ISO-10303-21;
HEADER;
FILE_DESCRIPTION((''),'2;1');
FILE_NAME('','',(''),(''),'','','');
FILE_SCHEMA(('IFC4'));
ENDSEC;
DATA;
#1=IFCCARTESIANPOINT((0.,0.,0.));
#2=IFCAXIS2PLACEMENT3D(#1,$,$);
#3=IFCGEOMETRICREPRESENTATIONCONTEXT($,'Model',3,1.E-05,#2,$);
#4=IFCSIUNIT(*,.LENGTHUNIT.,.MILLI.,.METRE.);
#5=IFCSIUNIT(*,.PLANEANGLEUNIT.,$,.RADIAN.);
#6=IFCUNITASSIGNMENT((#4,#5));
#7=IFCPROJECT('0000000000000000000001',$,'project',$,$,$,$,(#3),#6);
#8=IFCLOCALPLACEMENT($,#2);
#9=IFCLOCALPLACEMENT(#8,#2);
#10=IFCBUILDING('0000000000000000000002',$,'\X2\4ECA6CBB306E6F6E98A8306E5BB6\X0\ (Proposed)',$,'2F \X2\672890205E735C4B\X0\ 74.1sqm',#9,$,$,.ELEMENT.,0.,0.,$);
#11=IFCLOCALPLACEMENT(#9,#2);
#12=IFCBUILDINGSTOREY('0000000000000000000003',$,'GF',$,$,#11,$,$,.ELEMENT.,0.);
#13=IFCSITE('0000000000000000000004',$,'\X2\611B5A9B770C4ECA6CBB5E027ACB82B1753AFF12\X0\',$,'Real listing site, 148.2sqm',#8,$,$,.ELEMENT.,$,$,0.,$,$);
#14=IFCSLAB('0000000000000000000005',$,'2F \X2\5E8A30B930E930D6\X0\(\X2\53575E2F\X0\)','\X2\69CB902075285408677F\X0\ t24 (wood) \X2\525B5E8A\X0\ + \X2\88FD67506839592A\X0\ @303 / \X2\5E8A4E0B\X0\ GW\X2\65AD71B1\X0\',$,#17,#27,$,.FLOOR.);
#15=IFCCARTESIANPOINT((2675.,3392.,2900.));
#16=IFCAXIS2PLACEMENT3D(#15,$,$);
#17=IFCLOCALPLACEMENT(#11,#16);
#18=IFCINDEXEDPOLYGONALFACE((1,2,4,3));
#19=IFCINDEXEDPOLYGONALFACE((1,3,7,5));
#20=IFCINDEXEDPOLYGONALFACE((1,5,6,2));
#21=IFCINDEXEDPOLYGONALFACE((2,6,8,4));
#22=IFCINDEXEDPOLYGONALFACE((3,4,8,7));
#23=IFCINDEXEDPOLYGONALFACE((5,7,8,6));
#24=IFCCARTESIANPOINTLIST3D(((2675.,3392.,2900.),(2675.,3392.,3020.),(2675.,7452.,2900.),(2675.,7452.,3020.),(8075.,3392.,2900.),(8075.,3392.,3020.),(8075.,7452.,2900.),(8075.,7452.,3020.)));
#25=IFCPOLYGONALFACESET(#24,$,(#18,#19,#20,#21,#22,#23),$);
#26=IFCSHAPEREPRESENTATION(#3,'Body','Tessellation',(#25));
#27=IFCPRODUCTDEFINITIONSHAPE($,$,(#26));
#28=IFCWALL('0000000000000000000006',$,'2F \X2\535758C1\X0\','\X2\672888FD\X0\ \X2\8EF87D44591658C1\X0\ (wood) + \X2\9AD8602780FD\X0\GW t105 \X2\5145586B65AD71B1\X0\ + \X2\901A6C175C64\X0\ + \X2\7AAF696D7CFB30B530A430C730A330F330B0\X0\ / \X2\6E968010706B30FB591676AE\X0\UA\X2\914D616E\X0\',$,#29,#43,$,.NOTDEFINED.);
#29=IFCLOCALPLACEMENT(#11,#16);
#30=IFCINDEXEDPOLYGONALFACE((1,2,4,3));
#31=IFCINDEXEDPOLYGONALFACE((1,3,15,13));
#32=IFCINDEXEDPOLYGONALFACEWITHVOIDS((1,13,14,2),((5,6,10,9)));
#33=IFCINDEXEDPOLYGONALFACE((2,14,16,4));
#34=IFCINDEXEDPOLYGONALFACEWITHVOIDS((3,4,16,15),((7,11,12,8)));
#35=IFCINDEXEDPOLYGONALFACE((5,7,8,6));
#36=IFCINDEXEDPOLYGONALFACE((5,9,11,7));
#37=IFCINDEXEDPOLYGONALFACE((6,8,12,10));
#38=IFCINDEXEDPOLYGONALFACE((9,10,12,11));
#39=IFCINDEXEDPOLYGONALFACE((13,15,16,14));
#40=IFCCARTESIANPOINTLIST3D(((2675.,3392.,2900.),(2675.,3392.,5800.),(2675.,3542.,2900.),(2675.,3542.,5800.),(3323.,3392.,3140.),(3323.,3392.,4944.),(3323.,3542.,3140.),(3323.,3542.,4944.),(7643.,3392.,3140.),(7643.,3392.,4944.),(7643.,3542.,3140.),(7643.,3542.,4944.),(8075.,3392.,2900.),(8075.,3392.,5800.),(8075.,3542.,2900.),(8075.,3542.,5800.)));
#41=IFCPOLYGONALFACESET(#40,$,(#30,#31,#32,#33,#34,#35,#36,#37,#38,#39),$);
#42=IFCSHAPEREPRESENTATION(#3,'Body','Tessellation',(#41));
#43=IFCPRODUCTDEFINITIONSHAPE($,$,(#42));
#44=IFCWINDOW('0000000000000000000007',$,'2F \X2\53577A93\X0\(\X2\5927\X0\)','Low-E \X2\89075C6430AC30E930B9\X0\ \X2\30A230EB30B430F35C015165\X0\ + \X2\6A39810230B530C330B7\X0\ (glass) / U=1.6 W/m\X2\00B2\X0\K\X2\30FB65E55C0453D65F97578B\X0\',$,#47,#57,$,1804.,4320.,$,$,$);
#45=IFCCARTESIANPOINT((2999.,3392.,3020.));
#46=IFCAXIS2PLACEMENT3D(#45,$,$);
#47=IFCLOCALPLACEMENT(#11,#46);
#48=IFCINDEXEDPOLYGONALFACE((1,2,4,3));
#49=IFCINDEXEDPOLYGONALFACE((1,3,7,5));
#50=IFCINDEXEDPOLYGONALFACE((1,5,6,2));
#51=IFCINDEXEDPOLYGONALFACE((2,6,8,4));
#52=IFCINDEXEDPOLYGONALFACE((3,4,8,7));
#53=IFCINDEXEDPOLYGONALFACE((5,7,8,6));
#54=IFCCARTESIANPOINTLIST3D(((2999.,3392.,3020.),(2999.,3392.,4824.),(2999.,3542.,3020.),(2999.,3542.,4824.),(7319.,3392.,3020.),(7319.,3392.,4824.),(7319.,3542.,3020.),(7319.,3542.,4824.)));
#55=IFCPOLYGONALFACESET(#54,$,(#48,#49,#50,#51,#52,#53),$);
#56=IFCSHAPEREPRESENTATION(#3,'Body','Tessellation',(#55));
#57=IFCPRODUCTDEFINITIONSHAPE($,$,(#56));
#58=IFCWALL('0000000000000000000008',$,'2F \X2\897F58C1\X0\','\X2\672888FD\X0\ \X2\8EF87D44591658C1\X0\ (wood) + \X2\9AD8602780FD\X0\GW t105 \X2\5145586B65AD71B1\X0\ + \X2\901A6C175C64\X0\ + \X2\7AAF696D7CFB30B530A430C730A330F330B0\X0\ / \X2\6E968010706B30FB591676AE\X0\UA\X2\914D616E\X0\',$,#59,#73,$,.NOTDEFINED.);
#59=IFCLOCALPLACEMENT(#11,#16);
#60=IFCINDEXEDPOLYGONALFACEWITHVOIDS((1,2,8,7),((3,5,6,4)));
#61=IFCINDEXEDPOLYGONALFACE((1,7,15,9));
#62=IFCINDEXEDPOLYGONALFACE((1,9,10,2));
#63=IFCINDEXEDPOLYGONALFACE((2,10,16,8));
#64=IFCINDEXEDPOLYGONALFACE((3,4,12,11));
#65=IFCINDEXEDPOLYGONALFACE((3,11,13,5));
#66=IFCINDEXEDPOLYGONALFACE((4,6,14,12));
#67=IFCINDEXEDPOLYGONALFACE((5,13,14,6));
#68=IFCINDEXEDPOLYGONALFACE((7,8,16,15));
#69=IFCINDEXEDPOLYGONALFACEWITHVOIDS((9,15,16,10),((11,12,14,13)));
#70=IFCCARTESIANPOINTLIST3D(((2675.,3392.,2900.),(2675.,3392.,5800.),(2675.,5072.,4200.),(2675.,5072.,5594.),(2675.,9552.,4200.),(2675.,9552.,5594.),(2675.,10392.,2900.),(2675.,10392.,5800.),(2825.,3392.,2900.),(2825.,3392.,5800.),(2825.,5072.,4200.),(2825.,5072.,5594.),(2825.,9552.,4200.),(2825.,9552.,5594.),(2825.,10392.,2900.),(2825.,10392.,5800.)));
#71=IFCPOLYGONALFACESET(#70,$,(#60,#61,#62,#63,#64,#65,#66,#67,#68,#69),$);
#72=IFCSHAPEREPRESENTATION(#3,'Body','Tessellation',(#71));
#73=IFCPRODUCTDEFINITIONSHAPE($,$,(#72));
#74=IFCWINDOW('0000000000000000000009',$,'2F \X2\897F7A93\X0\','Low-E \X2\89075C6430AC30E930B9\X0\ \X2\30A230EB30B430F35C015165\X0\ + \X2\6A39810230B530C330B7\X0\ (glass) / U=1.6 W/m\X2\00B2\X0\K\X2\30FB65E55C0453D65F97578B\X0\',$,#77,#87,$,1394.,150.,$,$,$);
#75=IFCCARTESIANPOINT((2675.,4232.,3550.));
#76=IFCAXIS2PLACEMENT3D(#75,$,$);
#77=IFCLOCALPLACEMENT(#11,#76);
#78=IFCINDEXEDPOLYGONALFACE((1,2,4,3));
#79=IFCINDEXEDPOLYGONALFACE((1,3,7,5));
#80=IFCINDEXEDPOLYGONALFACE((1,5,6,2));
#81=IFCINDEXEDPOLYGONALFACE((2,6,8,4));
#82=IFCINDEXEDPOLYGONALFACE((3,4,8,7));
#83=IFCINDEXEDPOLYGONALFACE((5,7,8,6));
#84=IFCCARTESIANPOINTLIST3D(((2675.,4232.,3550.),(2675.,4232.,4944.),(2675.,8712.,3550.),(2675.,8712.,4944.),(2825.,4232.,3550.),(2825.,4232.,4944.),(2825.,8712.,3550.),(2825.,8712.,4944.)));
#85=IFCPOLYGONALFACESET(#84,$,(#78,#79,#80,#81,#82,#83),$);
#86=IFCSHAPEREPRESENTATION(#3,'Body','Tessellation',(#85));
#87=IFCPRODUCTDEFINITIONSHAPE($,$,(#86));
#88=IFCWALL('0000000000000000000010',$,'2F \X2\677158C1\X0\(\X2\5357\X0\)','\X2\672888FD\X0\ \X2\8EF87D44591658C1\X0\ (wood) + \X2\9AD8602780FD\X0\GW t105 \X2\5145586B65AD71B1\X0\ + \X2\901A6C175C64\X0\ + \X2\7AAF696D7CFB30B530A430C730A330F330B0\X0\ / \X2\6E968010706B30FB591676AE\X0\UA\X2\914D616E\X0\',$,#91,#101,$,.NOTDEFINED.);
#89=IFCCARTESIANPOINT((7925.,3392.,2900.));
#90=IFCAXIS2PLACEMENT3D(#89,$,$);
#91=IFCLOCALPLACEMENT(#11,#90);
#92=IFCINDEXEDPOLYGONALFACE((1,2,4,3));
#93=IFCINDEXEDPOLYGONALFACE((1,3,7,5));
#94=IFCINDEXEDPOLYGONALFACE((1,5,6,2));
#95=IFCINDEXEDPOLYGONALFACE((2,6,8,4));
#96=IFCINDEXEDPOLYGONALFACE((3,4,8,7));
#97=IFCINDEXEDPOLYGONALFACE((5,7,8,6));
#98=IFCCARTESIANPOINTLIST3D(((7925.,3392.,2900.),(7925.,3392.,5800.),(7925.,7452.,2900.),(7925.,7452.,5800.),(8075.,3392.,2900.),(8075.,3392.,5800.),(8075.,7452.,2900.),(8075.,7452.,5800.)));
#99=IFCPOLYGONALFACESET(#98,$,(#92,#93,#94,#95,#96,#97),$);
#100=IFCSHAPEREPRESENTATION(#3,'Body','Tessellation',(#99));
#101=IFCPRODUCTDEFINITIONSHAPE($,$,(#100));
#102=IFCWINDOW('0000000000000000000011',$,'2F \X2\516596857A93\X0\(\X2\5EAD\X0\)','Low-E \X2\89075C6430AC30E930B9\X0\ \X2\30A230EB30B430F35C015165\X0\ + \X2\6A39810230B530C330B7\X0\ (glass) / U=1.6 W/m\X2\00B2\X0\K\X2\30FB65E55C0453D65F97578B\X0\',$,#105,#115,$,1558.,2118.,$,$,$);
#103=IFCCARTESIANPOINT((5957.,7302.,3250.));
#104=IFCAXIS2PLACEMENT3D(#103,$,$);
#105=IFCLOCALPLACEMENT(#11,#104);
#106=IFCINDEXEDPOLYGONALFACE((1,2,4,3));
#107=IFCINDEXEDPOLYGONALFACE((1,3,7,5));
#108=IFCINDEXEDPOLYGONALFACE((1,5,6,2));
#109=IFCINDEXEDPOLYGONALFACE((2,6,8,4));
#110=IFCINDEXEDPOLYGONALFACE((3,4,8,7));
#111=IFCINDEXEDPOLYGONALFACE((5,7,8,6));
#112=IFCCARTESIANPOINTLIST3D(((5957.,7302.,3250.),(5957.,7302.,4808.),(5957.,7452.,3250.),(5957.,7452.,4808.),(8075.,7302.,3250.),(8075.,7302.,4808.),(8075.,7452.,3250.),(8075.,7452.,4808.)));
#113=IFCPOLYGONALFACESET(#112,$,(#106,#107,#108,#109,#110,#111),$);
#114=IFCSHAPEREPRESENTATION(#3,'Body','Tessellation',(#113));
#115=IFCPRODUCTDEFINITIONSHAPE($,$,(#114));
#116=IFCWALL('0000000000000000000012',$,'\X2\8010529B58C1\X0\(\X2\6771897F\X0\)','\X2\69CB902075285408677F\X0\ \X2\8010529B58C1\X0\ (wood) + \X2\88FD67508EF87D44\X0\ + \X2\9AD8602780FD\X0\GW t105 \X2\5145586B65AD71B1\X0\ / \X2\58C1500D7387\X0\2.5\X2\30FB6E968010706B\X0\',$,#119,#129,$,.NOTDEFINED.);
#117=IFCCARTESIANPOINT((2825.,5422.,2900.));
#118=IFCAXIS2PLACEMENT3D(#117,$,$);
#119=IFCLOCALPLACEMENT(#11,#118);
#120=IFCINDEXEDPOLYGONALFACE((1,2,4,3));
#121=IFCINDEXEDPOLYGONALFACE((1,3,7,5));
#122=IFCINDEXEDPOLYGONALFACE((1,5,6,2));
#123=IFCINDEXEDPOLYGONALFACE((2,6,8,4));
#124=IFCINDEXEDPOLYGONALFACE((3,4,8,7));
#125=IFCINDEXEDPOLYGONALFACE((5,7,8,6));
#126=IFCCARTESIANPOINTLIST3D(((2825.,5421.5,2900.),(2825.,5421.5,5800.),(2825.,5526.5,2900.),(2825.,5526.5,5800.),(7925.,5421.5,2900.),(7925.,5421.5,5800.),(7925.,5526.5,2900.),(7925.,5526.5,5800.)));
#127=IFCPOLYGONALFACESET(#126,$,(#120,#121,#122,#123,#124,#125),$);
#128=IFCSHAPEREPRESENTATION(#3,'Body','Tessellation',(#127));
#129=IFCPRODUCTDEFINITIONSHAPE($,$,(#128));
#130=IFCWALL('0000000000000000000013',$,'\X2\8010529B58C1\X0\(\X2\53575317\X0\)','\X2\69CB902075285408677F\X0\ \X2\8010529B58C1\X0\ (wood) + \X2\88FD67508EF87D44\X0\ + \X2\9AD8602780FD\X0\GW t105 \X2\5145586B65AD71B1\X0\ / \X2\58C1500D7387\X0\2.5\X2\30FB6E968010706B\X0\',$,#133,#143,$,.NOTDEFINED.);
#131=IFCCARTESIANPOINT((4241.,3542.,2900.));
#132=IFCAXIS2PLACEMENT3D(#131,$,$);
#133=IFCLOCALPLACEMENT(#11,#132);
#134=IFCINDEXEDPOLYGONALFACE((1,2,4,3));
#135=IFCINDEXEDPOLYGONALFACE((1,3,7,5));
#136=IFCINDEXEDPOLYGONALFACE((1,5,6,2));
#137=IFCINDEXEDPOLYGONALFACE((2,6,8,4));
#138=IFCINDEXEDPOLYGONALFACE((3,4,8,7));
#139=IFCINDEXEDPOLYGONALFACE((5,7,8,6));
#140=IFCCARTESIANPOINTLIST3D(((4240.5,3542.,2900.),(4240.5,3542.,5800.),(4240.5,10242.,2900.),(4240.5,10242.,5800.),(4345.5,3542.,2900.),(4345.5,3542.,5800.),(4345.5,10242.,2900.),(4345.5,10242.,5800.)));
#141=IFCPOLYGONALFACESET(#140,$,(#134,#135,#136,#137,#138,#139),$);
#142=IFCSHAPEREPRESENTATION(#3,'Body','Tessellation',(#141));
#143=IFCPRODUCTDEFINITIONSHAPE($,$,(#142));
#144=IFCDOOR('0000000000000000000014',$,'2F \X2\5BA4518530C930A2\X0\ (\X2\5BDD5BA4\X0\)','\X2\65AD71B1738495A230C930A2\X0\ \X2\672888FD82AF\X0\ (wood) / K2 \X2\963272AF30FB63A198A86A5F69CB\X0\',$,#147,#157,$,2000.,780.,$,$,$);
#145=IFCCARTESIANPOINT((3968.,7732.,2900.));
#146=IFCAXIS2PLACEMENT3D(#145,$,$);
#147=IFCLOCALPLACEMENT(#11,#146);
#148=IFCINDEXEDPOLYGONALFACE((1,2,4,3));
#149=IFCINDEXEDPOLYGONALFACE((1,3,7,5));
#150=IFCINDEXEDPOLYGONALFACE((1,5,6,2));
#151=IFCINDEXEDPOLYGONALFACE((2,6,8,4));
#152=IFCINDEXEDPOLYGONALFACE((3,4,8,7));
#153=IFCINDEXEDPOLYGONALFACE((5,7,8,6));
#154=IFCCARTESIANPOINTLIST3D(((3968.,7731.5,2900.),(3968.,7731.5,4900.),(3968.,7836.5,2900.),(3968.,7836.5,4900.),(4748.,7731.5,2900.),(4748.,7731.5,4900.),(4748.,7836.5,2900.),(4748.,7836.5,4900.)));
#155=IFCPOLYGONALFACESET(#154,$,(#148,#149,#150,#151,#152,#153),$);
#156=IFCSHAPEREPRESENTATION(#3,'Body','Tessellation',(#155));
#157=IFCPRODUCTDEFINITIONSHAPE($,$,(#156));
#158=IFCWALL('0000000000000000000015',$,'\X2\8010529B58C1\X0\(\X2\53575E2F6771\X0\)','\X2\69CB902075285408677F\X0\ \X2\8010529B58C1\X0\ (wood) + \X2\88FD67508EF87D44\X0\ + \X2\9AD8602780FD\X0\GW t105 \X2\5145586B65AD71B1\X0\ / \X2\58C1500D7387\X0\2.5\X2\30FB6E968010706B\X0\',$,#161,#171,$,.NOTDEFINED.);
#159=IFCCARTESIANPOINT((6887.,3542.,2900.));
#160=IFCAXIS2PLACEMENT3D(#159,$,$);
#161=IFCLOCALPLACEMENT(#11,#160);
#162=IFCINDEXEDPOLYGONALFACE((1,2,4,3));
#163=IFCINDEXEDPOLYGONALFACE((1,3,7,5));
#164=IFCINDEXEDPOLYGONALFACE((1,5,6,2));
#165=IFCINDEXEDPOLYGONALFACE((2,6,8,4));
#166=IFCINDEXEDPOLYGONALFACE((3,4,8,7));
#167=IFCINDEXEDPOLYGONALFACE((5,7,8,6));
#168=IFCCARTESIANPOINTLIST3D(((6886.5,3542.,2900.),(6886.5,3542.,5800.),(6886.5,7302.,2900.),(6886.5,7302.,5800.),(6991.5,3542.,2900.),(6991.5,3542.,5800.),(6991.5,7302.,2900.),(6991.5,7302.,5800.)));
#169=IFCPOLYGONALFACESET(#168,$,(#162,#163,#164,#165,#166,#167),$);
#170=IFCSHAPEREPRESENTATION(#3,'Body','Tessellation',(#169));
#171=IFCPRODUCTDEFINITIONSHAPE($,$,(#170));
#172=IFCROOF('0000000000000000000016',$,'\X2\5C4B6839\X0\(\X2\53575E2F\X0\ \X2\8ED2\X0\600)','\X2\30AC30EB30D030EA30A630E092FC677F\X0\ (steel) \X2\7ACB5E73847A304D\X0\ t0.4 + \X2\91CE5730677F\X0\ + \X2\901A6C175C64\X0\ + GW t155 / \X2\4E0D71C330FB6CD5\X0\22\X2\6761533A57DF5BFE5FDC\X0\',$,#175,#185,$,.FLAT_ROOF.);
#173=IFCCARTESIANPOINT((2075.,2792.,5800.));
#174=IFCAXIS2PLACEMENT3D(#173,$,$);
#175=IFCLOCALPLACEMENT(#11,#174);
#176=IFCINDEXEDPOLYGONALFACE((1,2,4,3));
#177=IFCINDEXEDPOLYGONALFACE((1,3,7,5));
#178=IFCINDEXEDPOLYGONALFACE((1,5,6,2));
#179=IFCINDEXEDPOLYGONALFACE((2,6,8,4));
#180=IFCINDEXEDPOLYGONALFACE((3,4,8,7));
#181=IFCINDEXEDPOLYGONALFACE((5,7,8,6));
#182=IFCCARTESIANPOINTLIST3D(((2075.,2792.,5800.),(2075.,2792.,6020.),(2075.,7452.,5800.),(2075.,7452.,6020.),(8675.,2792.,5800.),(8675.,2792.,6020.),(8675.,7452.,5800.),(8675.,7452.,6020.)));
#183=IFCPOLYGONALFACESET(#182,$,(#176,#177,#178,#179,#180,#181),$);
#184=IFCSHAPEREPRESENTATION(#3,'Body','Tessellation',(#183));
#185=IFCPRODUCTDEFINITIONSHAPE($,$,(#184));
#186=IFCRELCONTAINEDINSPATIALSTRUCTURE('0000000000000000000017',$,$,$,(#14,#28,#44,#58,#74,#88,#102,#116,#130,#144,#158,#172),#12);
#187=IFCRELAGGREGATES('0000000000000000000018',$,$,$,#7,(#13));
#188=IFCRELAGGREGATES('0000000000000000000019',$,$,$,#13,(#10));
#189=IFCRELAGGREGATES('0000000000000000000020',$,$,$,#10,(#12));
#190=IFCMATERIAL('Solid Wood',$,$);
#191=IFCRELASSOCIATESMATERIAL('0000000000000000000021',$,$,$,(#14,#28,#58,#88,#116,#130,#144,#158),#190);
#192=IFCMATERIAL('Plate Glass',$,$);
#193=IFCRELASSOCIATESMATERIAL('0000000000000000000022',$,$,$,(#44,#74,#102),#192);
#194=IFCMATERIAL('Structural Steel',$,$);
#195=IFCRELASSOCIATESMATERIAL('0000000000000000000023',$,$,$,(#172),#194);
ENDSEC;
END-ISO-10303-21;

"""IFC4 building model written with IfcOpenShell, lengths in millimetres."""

from ifc_helpers import new_model, si_unit, frame, frame_2d, origin, place, context, project, spatial, rectangle, extrude, material, element, fill, save


model = new_model("IFC4")

# Units and contexts
model_context = context("Model", 3, precision=1e-05, world=origin())
ifc_project = project(units=[si_unit("LENGTHUNIT", "METRE", prefix="MILLI"), si_unit("PLANEANGLEUNIT", "RADIAN")], contexts=[model_context])

# Site, building, storey
site_placement = place(None, origin())
site = spatial("IfcSite", under=ifc_project, at=site_placement, Name="愛媛県今治市立花町２", ObjectType="Real listing site, 148.2sqm", CompositionType="ELEMENT", RefElevation=0.0)
building_placement = place(site_placement, origin())
building = spatial("IfcBuilding", under=site, at=building_placement, Name="今治の潮風の家 (Proposed)", ObjectType="2F 木造平屋 74.1sqm", CompositionType="ELEMENT", ElevationOfRefHeight=0.0, ElevationOfTerrain=0.0)
storey_placement = place(building_placement, origin())
storey = spatial("IfcBuildingStorey", under=building, at=storey_placement, Name="GF", CompositionType="ELEMENT", Elevation=0.0)

# Slab
ifc_material_1 = material(Name="Solid Wood")
slab_placement = place(storey_placement, frame((2675.0, 3392.0, 2900.0)))
element("IfcSlab", 1, at=slab_placement, inside=storey, material=ifc_material_1, Name="2F 床スラブ(南帯)", Description="構造用合板 t24 (wood) 剛床 + 製材根太 @303 / 床下 GW断熱", PredefinedType="FLOOR", context=model_context, shape_type="SweptSolid", body=[
    extrude(rectangle(XDim=5400.0, YDim=4060.0, at=frame_2d((2700.0, 2030.0))), frame((2675.0, 3392.0, 2900.0)), (0.0, 0.0, 1.0), 120.0),
])

# Walls, openings, windows
wall_1_placement = place(storey_placement, frame((2675.0, 3392.0, 2900.0)))
wall_1 = element("IfcWall", 2, at=wall_1_placement, inside=storey, material=ifc_material_1, Name="2F 南壁", Description="木製 軸組外壁 (wood) + 高性能GW t105 充填断熱 + 通気層 + 窯業系サイディング / 準耐火・外皮UA配慮", PredefinedType="NOTDEFINED", context=model_context, shape_type="SweptSolid", body=[
    extrude(rectangle(XDim=5400.0, YDim=150.0, at=frame_2d((2700.0, 75.0))), frame((2675.0, 3392.0, 2900.0)), (0.0, 0.0, 1.0), 2900.0),
])
opening_1_placement = place(storey_placement, frame((2999.0, 3392.0, 3020.0)))
opening_1 = element("IfcOpeningElement", 3, at=opening_1_placement, cuts=wall_1, PredefinedType="NOTDEFINED", context=model_context, shape_type="SweptSolid", body=[
    extrude(rectangle(XDim=4320.0, YDim=150.0, at=frame_2d((2160.0, 75.0))), frame((2999.0, 3392.0, 3020.0)), (0.0, 0.0, 1.0), 1804.0),
])
ifc_material_2 = material(Name="Plate Glass")
window_1_placement = place(storey_placement, frame((2999.0, 3392.0, 3020.0)))
window_1 = element("IfcWindow", 4, at=window_1_placement, inside=storey, material=ifc_material_2, Name="2F 南窓(大)", Description="Low-E 複層ガラス アルゴン封入 + 樹脂サッシ (glass) / U=1.6 W/m²K・日射取得型", OverallHeight=1804.0, OverallWidth=4320.0, context=model_context, shape_type="SweptSolid", body=[
    extrude(rectangle(XDim=4320.0, YDim=150.0, at=frame_2d((2160.0, 75.0))), frame((2999.0, 3392.0, 3020.0)), (0.0, 0.0, 1.0), 1804.0),
])
fill(opening_1, window_1)
wall_2_placement = place(storey_placement, frame((2675.0, 3392.0, 2900.0)))
wall_2 = element("IfcWall", 5, at=wall_2_placement, inside=storey, material=ifc_material_1, Name="2F 西壁", Description="木製 軸組外壁 (wood) + 高性能GW t105 充填断熱 + 通気層 + 窯業系サイディング / 準耐火・外皮UA配慮", PredefinedType="NOTDEFINED", context=model_context, shape_type="SweptSolid", body=[
    extrude(rectangle(XDim=150.0, YDim=7000.0, at=frame_2d((75.0, 3500.0))), frame((2675.0, 3392.0, 2900.0)), (0.0, 0.0, 1.0), 2900.0),
])
opening_2_placement = place(storey_placement, frame((2675.0, 4232.0, 3550.0)))
opening_2 = element("IfcOpeningElement", 6, at=opening_2_placement, cuts=wall_2, PredefinedType="NOTDEFINED", context=model_context, shape_type="SweptSolid", body=[
    extrude(rectangle(XDim=150.0, YDim=4480.0, at=frame_2d((75.0, 2240.0))), frame((2675.0, 4232.0, 3550.0)), (0.0, 0.0, 1.0), 1394.0),
])
window_2_placement = place(storey_placement, frame((2675.0, 4232.0, 3550.0)))
window_2 = element("IfcWindow", 7, at=window_2_placement, inside=storey, material=ifc_material_2, Name="2F 西窓", Description="Low-E 複層ガラス アルゴン封入 + 樹脂サッシ (glass) / U=1.6 W/m²K・日射取得型", OverallHeight=1394.0, OverallWidth=150.0, context=model_context, shape_type="SweptSolid", body=[
    extrude(rectangle(XDim=150.0, YDim=4480.0, at=frame_2d((75.0, 2240.0))), frame((2675.0, 4232.0, 3550.0)), (0.0, 0.0, 1.0), 1394.0),
])
fill(opening_2, window_2)
wall_3_placement = place(storey_placement, frame((7925.0, 3392.0, 2900.0)))
wall_3 = element("IfcWall", 8, at=wall_3_placement, inside=storey, material=ifc_material_1, Name="2F 東壁(南)", Description="木製 軸組外壁 (wood) + 高性能GW t105 充填断熱 + 通気層 + 窯業系サイディング / 準耐火・外皮UA配慮", PredefinedType="NOTDEFINED", context=model_context, shape_type="SweptSolid", body=[
    extrude(rectangle(XDim=150.0, YDim=4060.0, at=frame_2d((75.0, 2030.0))), frame((7925.0, 3392.0, 2900.0)), (0.0, 0.0, 1.0), 2900.0),
])
opening_3_placement = place(storey_placement, frame((5957.0, 7302.0, 3250.0)))
opening_3 = element("IfcOpeningElement", 9, at=opening_3_placement, cuts=wall_3, PredefinedType="NOTDEFINED", context=model_context, shape_type="SweptSolid", body=[
    extrude(rectangle(XDim=2118.0, YDim=150.0, at=frame_2d((1059.0, 75.0))), frame((5957.0, 7302.0, 3250.0)), (0.0, 0.0, 1.0), 1558.0),
])
window_3_placement = place(storey_placement, frame((5957.0, 7302.0, 3250.0)))
window_3 = element("IfcWindow", 10, at=window_3_placement, inside=storey, material=ifc_material_2, Name="2F 入隅窓(庭)", Description="Low-E 複層ガラス アルゴン封入 + 樹脂サッシ (glass) / U=1.6 W/m²K・日射取得型", OverallHeight=1558.0, OverallWidth=2118.0, context=model_context, shape_type="SweptSolid", body=[
    extrude(rectangle(XDim=2118.0, YDim=150.0, at=frame_2d((1059.0, 75.0))), frame((5957.0, 7302.0, 3250.0)), (0.0, 0.0, 1.0), 1558.0),
])
fill(opening_3, window_3)

# Wall
wall_4_placement = place(storey_placement, frame((2825.0, 5422.0, 2900.0)))
element("IfcWall", 11, at=wall_4_placement, inside=storey, material=ifc_material_1, Name="耐力壁(東西)", Description="構造用合板 耐力壁 (wood) + 製材軸組 + 高性能GW t105 充填断熱 / 壁倍率2.5・準耐火", PredefinedType="NOTDEFINED", context=model_context, shape_type="SweptSolid", body=[
    extrude(rectangle(XDim=5100.0, YDim=105.0, at=frame_2d((2550.0, 52.0))), frame((2825.0, 5422.0, 2900.0)), (0.0, 0.0, 1.0), 2900.0),
])

# Wall, opening, door
wall_5_placement = place(storey_placement, frame((4241.0, 3542.0, 2900.0)))
wall_5 = element("IfcWall", 12, at=wall_5_placement, inside=storey, material=ifc_material_1, Name="耐力壁(南北)", Description="構造用合板 耐力壁 (wood) + 製材軸組 + 高性能GW t105 充填断熱 / 壁倍率2.5・準耐火", PredefinedType="NOTDEFINED", context=model_context, shape_type="SweptSolid", body=[
    extrude(rectangle(XDim=105.0, YDim=6700.0, at=frame_2d((52.0, 3350.0))), frame((4241.0, 3542.0, 2900.0)), (0.0, 0.0, 1.0), 2900.0),
])
opening_4_placement = place(storey_placement, frame((3968.0, 7732.0, 2900.0)))
opening_4 = element("IfcOpeningElement", 13, at=opening_4_placement, cuts=wall_5, PredefinedType="NOTDEFINED", context=model_context, shape_type="SweptSolid", body=[
    extrude(rectangle(XDim=780.0, YDim=105.0, at=frame_2d((390.0, 52.0))), frame((3968.0, 7732.0, 2900.0)), (0.0, 0.0, 1.0), 2000.0),
])
door_placement = place(storey_placement, frame((3968.0, 7732.0, 2900.0)))
door = element("IfcDoor", 14, at=door_placement, inside=storey, material=ifc_material_1, Name="2F 室内ドア (寝室)", Description="断熱玄関ドア 木製芯 (wood) / K2 防犯・採風機構", OverallHeight=2000.0, OverallWidth=780.0, context=model_context, shape_type="SweptSolid", body=[
    extrude(rectangle(XDim=780.0, YDim=105.0, at=frame_2d((390.0, 52.0))), frame((3968.0, 7732.0, 2900.0)), (0.0, 0.0, 1.0), 2000.0),
])
fill(opening_4, door)

# Wall
wall_6_placement = place(storey_placement, frame((6887.0, 3542.0, 2900.0)))
element("IfcWall", 15, at=wall_6_placement, inside=storey, material=ifc_material_1, Name="耐力壁(南帯東)", Description="構造用合板 耐力壁 (wood) + 製材軸組 + 高性能GW t105 充填断熱 / 壁倍率2.5・準耐火", PredefinedType="NOTDEFINED", context=model_context, shape_type="SweptSolid", body=[
    extrude(rectangle(XDim=105.0, YDim=3760.0, at=frame_2d((52.0, 1880.0))), frame((6887.0, 3542.0, 2900.0)), (0.0, 0.0, 1.0), 2900.0),
])

# Roof
ifc_material_3 = material(Name="Structural Steel")
for number, where, name in (
    (16, (2075.0, 2792.0, 5800.0), "屋根(南帯 軒600)"),
):
    element("IfcRoof", number, at=place(storey_placement, frame(where)), inside=storey, material=ifc_material_3, Name=name, Description="ガルバリウム鋼板 (steel) 立平葺き t0.4 + 野地板 + 通気層 + GW t155 / 不燃・法22条区域対応", PredefinedType="FLAT_ROOF", context=model_context, shape_type="SweptSolid", body=[
        extrude(rectangle(XDim=6600.0, YDim=4660.0, at=frame_2d((3300.0, 2330.0))), frame((2075.0, 2792.0, 5800.0)), (0.0, 0.0, 1.0), 220.0),
    ])

save(model, "model.ifc")
